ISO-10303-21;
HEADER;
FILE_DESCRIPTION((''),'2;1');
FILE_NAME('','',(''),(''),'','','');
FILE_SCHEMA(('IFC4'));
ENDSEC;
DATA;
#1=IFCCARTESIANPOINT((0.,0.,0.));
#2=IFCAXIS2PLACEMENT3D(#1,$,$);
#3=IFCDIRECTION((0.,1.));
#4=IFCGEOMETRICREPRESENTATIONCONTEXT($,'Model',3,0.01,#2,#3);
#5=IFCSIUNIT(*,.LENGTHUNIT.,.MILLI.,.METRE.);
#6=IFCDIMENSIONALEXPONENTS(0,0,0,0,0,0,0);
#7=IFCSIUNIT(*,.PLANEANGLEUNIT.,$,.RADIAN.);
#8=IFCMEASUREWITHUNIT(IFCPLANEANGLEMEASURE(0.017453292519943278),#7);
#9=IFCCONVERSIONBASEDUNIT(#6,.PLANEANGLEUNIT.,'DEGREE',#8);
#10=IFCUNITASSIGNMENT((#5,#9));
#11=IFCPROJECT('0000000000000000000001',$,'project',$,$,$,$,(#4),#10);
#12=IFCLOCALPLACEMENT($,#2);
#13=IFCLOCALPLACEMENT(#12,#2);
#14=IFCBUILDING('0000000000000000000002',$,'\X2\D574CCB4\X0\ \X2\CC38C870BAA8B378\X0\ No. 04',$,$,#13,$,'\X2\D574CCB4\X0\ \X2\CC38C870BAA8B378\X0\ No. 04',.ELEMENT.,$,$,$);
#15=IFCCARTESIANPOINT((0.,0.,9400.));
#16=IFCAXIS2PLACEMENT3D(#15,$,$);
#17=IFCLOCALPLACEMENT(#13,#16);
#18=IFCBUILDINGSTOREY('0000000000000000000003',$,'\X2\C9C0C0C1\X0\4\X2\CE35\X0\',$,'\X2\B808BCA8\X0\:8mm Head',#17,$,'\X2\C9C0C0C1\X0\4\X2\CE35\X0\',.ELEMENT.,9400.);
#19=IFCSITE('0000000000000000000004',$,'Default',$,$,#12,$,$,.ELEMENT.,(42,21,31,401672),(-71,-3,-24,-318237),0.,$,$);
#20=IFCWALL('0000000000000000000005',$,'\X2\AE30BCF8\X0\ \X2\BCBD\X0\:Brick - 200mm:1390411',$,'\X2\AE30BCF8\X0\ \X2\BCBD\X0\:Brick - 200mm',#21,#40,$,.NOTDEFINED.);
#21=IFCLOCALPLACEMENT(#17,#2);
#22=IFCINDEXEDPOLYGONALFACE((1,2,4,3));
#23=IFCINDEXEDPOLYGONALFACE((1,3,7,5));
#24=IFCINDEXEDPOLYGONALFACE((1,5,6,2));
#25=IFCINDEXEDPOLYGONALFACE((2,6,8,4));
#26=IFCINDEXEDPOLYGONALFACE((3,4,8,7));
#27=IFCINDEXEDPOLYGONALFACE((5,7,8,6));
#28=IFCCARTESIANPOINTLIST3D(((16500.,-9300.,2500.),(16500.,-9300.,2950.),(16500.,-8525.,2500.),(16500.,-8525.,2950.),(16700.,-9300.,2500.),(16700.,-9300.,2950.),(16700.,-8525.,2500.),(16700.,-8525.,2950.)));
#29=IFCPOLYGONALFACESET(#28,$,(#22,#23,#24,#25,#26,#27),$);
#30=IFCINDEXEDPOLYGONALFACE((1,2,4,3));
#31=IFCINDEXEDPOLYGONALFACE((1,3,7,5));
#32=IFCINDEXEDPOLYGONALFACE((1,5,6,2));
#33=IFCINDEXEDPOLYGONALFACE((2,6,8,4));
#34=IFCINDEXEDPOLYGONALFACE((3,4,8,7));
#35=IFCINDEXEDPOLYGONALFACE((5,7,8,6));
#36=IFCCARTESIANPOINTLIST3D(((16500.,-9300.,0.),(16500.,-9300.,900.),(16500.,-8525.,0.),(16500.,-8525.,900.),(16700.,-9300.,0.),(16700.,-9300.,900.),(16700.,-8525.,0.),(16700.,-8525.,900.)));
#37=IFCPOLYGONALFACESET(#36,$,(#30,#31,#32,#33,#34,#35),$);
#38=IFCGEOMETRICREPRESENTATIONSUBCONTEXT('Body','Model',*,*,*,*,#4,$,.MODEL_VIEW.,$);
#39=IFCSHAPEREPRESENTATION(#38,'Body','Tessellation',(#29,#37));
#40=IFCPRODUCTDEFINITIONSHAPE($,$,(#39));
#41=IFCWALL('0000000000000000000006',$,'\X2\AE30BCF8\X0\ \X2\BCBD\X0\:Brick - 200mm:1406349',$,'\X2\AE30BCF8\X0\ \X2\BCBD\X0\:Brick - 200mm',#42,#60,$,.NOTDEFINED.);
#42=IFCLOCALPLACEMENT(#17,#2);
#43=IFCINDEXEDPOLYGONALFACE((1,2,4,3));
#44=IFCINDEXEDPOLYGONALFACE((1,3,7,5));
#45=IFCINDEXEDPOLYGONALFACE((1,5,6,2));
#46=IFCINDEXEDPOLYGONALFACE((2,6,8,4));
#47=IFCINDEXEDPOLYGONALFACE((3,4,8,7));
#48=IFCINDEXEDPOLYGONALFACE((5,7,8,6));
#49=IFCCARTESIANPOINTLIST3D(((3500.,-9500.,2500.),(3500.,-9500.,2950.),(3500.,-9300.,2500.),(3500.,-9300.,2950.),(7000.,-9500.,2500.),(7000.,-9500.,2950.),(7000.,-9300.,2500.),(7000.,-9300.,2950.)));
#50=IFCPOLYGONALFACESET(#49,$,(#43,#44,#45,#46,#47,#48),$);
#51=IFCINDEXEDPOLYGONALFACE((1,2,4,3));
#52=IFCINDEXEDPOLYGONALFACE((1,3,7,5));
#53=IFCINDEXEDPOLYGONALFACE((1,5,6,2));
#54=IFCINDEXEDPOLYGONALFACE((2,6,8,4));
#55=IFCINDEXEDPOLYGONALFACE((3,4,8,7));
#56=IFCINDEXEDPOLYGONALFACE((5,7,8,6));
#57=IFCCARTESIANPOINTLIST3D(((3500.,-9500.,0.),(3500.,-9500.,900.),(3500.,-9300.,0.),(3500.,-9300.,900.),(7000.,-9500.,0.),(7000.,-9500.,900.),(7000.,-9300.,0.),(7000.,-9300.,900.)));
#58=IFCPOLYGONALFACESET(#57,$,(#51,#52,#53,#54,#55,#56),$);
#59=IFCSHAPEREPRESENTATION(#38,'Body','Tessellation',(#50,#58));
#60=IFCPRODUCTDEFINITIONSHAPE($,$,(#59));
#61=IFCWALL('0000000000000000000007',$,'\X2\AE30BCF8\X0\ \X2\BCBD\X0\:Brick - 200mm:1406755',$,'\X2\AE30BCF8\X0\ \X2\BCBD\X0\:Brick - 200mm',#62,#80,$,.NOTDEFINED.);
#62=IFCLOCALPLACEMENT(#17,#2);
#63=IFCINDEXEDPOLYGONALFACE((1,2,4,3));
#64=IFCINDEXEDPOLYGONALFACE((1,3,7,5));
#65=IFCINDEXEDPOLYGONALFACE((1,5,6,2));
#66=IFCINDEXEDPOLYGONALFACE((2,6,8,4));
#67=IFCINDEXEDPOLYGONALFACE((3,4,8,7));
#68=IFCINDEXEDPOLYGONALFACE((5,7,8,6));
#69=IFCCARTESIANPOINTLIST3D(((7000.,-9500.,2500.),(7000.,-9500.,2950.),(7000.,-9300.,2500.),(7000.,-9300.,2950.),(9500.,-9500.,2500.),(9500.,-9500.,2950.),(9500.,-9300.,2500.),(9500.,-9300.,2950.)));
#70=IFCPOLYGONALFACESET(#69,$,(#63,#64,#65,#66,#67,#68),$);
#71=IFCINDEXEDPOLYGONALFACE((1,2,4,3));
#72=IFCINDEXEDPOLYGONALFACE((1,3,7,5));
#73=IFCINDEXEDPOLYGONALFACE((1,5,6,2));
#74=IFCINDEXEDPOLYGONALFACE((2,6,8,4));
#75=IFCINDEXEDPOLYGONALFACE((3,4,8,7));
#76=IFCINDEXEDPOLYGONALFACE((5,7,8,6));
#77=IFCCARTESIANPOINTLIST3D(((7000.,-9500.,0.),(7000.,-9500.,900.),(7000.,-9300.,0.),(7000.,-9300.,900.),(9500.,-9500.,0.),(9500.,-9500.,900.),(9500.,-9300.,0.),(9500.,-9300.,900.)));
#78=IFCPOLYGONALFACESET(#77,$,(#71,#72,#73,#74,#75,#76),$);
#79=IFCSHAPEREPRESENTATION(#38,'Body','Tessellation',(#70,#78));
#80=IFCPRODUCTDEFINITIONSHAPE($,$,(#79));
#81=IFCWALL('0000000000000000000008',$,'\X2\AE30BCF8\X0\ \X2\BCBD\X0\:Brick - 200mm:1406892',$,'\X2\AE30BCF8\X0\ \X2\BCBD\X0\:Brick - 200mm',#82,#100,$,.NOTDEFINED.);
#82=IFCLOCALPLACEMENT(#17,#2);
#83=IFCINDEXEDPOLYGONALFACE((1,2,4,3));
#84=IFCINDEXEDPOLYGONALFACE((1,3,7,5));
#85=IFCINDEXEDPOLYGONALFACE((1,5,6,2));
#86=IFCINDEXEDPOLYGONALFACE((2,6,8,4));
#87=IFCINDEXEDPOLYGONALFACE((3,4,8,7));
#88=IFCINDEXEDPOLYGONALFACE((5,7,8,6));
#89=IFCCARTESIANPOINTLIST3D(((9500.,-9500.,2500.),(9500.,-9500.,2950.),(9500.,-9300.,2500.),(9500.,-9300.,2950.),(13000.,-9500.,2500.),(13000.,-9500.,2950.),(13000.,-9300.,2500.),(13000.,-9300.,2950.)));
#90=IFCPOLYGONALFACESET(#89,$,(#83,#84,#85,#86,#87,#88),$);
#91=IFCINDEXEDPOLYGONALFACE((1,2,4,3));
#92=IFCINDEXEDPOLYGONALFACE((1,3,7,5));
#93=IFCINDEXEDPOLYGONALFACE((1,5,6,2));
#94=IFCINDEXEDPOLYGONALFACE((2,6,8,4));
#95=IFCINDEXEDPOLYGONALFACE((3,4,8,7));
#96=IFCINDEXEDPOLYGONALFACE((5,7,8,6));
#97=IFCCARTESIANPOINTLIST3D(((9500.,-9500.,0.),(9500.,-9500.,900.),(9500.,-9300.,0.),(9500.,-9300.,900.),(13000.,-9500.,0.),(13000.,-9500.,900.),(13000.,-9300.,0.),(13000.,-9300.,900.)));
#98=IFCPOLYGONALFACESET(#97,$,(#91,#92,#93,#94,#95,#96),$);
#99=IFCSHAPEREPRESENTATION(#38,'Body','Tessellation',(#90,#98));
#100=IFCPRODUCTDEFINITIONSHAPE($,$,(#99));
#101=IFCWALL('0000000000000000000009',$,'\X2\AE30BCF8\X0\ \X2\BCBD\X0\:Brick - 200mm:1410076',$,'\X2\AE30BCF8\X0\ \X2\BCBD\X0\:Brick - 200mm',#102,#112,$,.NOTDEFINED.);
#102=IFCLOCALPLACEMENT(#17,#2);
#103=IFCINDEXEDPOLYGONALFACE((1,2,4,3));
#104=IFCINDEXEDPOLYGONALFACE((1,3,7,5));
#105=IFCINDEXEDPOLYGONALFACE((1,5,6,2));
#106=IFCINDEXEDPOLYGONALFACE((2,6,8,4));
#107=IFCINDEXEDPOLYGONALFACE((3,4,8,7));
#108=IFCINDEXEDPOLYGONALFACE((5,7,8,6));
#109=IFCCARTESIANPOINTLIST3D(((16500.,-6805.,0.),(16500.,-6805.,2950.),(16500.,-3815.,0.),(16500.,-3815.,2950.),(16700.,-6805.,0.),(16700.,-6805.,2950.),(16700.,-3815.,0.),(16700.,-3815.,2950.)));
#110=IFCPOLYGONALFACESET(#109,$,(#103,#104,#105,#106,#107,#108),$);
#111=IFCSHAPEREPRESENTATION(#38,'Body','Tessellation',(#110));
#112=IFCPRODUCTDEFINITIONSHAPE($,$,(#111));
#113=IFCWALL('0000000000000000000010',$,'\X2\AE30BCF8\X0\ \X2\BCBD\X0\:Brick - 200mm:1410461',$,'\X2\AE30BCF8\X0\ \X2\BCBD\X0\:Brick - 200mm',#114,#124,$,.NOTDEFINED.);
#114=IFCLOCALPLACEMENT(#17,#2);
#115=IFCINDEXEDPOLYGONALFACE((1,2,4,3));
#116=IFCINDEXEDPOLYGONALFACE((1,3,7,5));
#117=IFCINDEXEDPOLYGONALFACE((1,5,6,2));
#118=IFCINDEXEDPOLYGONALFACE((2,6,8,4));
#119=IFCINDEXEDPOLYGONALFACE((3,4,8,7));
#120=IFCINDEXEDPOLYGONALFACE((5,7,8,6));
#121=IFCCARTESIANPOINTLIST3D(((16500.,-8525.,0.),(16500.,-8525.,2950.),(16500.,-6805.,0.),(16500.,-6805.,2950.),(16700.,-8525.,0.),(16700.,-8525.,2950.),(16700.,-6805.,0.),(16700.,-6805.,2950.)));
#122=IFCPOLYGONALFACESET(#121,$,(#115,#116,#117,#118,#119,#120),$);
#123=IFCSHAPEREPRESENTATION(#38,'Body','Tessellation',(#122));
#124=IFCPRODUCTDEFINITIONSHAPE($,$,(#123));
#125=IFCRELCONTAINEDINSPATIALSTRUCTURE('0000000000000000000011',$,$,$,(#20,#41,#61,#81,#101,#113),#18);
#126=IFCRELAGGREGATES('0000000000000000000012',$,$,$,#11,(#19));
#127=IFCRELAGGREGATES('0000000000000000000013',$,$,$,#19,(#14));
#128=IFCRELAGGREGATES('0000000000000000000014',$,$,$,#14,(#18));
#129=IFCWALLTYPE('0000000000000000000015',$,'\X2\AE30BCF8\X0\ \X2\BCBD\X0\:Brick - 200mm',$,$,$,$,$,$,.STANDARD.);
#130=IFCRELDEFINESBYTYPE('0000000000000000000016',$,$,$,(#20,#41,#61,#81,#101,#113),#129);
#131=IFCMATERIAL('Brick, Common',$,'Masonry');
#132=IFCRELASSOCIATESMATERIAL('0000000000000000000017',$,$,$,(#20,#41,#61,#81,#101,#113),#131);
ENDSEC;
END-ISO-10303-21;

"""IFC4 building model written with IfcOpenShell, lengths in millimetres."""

from ifc_helpers import new_model, entity, si_unit, converted_unit, direction, frame, origin, place, context, subcontext, project, spatial, indexed_curve, outline, extrude, material, type_object, element, save


model = new_model("IFC4")

# Units and contexts
model_context = context("Model", 3, precision=0.01, world=origin(), true_north=direction((0.0, 1.0)))
body_context = subcontext(model_context, "Body", "Model", "MODEL_VIEW")
ifc_project = project(units=[si_unit("LENGTHUNIT", "METRE", prefix="MILLI"), converted_unit("PLANEANGLEUNIT", "DEGREE", entity("IfcPlaneAngleMeasure", 0.017453292519943278), si_unit("PLANEANGLEUNIT", "RADIAN"), dimensions=[0, 0, 0, 0, 0, 0, 0])], contexts=[model_context])

# Site, building, storey
site_placement = place(None, origin())
site = spatial("IfcSite", under=ifc_project, at=site_placement, Name="Default", CompositionType="ELEMENT", RefLatitude=(42, 21, 31, 401672), RefLongitude=(-71, -3, -24, -318237), RefElevation=0.0)
building_placement = place(site_placement, origin())
building = spatial("IfcBuilding", under=site, at=building_placement, Name="해체 참조모델 No. 04", LongName="해체 참조모델 No. 04", CompositionType="ELEMENT")
storey_placement = place(building_placement, frame((0.0, 0.0, 9400.0)))
storey = spatial("IfcBuildingStorey", under=building, at=storey_placement, Name="지상4층", ObjectType="레벨:8mm Head", LongName="지상4층", CompositionType="ELEMENT", Elevation=9400.0)

# Shared definitions
ifc_material_1 = material(Name="Brick, Common", Category="Masonry")
wall_type = type_object("IfcWallType", Name="기본 벽:Brick - 200mm", PredefinedType="STANDARD")

# Walls, openings
wall_1_placement = place(storey_placement, frame((16600.0, -9300.0, 0.0), z_axis=(0.0, 0.0, 1.0), x_axis=(0.0, 1.0, 0.0)))
wall_1 = element("IfcWall", 1, at=wall_1_placement, inside=storey, type_object=wall_type, material=ifc_material_1, Name="기본 벽:Brick - 200mm:1390411", ObjectType="기본 벽:Brick - 200mm", PredefinedType="NOTDEFINED", context=body_context, shape_type="SweptSolid", body=[
    extrude(outline(indexed_curve([(-100.0, -387.5), (100.0, -387.5), (100.0, 387.5), (-100.0, 387.5), (-100.0, -387.5)], self_intersect=False)), frame((387.5, 0.0, 2500.0), z_axis=(0.0, 0.0, 1.0), x_axis=(0.0, 1.0, 0.0)), (0.0, 0.0, 1.0), 450.0),
    extrude(outline(indexed_curve([(-100.0, -387.5), (100.0, -387.5), (100.0, 387.5), (-100.0, 387.5), (-100.0, -387.5)], self_intersect=False)), frame((387.5, 0.0, 0.0), z_axis=(0.0, 0.0, 1.0), x_axis=(0.0, 1.0, 0.0)), (0.0, 0.0, 1.0), 900.0),
])
opening_1_placement = place(wall_1_placement, origin())
element("IfcOpeningElement", 2, at=opening_1_placement, cuts=wall_1, PredefinedType="OPENING", context=body_context, shape_type="SweptSolid", body=[
    extrude(outline(indexed_curve([(-800.0, -387.5), (800.0, -387.5), (800.0, 387.5), (-800.0, 387.5), (-800.0, -387.5)], self_intersect=False)), frame((387.5, -252.4, 1700.0), z_axis=(0.0, 1.0, 0.0), x_axis=(0.0, 0.0, 1.0)), (0.0, 0.0, 1.0), 504.8),
])
wall_2_placement = place(storey_placement, frame((3500.0, -9400.0, 0.0)))
wall_2 = element("IfcWall", 3, at=wall_2_placement, inside=storey, type_object=wall_type, material=ifc_material_1, Name="기본 벽:Brick - 200mm:1406349", ObjectType="기본 벽:Brick - 200mm", PredefinedType="NOTDEFINED", context=body_context, shape_type="SweptSolid", body=[
    extrude(outline(indexed_curve([(-100.0, -1750.0), (100.0, -1750.0), (100.0, 1750.0), (-100.0, 1750.0), (-100.0, -1750.0)], self_intersect=False)), frame((1750.0, 0.0, 2500.0), z_axis=(0.0, 0.0, 1.0), x_axis=(0.0, 1.0, 0.0)), (0.0, 0.0, 1.0), 450.0),
    extrude(outline(indexed_curve([(-100.0, -1750.0), (100.0, -1750.0), (100.0, 1750.0), (-100.0, 1750.0), (-100.0, -1750.0)], self_intersect=False)), frame((1750.0, 0.0, 0.0), z_axis=(0.0, 0.0, 1.0), x_axis=(0.0, 1.0, 0.0)), (0.0, 0.0, 1.0), 900.0),
])
opening_2_placement = place(wall_2_placement, origin())
element("IfcOpeningElement", 4, at=opening_2_placement, cuts=wall_2, PredefinedType="OPENING", context=body_context, shape_type="SweptSolid", body=[
    extrude(outline(indexed_curve([(-800.0, -8250.0), (800.0, -8250.0), (800.0, 8250.0), (-800.0, 8250.0), (-800.0, -8250.0)], self_intersect=False)), frame((4750.0, -252.4, 1700.0), z_axis=(0.0, 1.0, 0.0), x_axis=(0.0, 0.0, 1.0)), (0.0, 0.0, 1.0), 504.8),
])
wall_3_placement = place(storey_placement, frame((7000.0, -9400.0, 0.0)))
wall_3 = element("IfcWall", 5, at=wall_3_placement, inside=storey, type_object=wall_type, material=ifc_material_1, Name="기본 벽:Brick - 200mm:1406755", ObjectType="기본 벽:Brick - 200mm", PredefinedType="NOTDEFINED", context=body_context, shape_type="SweptSolid", body=[
    extrude(outline(indexed_curve([(-100.0, -1250.0), (100.0, -1250.0), (100.0, 1250.0), (-100.0, 1250.0), (-100.0, -1250.0)], self_intersect=False)), frame((1250.0, 0.0, 2500.0), z_axis=(0.0, 0.0, 1.0), x_axis=(0.0, 1.0, 0.0)), (0.0, 0.0, 1.0), 450.0),
    extrude(outline(indexed_curve([(-100.0, -1250.0), (100.0, -1250.0), (100.0, 1250.0), (-100.0, 1250.0), (-100.0, -1250.0)], self_intersect=False)), frame((1250.0, 0.0, 0.0), z_axis=(0.0, 0.0, 1.0), x_axis=(0.0, 1.0, 0.0)), (0.0, 0.0, 1.0), 900.0),
])
opening_3_placement = place(wall_3_placement, origin())
element("IfcOpeningElement", 6, at=opening_3_placement, cuts=wall_3, PredefinedType="OPENING", context=body_context, shape_type="SweptSolid", body=[
    extrude(outline(indexed_curve([(-800.0, -8250.0), (800.0, -8250.0), (800.0, 8250.0), (-800.0, 8250.0), (-800.0, -8250.0)], self_intersect=False)), frame((1250.0, -252.4, 1700.0), z_axis=(0.0, 1.0, 0.0), x_axis=(0.0, 0.0, 1.0)), (0.0, 0.0, 1.0), 504.8),
])
wall_4_placement = place(storey_placement, frame((9500.0, -9400.0, 0.0)))
wall_4 = element("IfcWall", 7, at=wall_4_placement, inside=storey, type_object=wall_type, material=ifc_material_1, Name="기본 벽:Brick - 200mm:1406892", ObjectType="기본 벽:Brick - 200mm", PredefinedType="NOTDEFINED", context=body_context, shape_type="SweptSolid", body=[
    extrude(outline(indexed_curve([(-100.0, -1750.0), (100.0, -1750.0), (100.0, 1750.0), (-100.0, 1750.0), (-100.0, -1750.0)], self_intersect=False)), frame((1750.0, 0.0, 2500.0), z_axis=(0.0, 0.0, 1.0), x_axis=(0.0, 1.0, 0.0)), (0.0, 0.0, 1.0), 450.0),
    extrude(outline(indexed_curve([(-100.0, -1750.0), (100.0, -1750.0), (100.0, 1750.0), (-100.0, 1750.0), (-100.0, -1750.0)], self_intersect=False)), frame((1750.0, 0.0, 0.0), z_axis=(0.0, 0.0, 1.0), x_axis=(0.0, 1.0, 0.0)), (0.0, 0.0, 1.0), 900.0),
])
opening_4_placement = place(wall_4_placement, origin())
element("IfcOpeningElement", 8, at=opening_4_placement, cuts=wall_4, PredefinedType="OPENING", context=body_context, shape_type="SweptSolid", body=[
    extrude(outline(indexed_curve([(-800.0, -8250.0), (800.0, -8250.0), (800.0, 8250.0), (-800.0, 8250.0), (-800.0, -8250.0)], self_intersect=False)), frame((-1250.0, -252.4, 1700.0), z_axis=(0.0, 1.0, 0.0), x_axis=(0.0, 0.0, 1.0)), (0.0, 0.0, 1.0), 504.8),
])

# Walls
wall_5_placement = place(storey_placement, frame((16600.0, -3815.0, 0.0), z_axis=(0.0, 0.0, 1.0), x_axis=(0.0, -1.0, 0.0)))
element("IfcWall", 9, at=wall_5_placement, inside=storey, type_object=wall_type, material=ifc_material_1, Name="기본 벽:Brick - 200mm:1410076", ObjectType="기본 벽:Brick - 200mm", PredefinedType="NOTDEFINED", context=body_context, shape_type="SweptSolid", body=[
    extrude(outline(indexed_curve([(2990.0, 100.0), (0.0, 100.0), (0.0, -100.0), (2990.0, -100.0), (2990.0, 100.0)], self_intersect=False)), origin(), (0.0, 0.0, 1.0), 2950.0),
])
wall_6_placement = place(storey_placement, frame((16600.0, -6805.0, 0.0), z_axis=(0.0, 0.0, 1.0), x_axis=(0.0, -1.0, 0.0)))
element("IfcWall", 10, at=wall_6_placement, inside=storey, type_object=wall_type, material=ifc_material_1, Name="기본 벽:Brick - 200mm:1410461", ObjectType="기본 벽:Brick - 200mm", PredefinedType="NOTDEFINED", context=body_context, shape_type="SweptSolid", body=[
    extrude(outline(indexed_curve([(1720.0, 100.0), (0.0, 100.0), (0.0, -100.0), (1720.0, -100.0), (1720.0, 100.0)], self_intersect=False)), origin(), (0.0, 0.0, 1.0), 2950.0),
])

save(model, "model.ifc")
